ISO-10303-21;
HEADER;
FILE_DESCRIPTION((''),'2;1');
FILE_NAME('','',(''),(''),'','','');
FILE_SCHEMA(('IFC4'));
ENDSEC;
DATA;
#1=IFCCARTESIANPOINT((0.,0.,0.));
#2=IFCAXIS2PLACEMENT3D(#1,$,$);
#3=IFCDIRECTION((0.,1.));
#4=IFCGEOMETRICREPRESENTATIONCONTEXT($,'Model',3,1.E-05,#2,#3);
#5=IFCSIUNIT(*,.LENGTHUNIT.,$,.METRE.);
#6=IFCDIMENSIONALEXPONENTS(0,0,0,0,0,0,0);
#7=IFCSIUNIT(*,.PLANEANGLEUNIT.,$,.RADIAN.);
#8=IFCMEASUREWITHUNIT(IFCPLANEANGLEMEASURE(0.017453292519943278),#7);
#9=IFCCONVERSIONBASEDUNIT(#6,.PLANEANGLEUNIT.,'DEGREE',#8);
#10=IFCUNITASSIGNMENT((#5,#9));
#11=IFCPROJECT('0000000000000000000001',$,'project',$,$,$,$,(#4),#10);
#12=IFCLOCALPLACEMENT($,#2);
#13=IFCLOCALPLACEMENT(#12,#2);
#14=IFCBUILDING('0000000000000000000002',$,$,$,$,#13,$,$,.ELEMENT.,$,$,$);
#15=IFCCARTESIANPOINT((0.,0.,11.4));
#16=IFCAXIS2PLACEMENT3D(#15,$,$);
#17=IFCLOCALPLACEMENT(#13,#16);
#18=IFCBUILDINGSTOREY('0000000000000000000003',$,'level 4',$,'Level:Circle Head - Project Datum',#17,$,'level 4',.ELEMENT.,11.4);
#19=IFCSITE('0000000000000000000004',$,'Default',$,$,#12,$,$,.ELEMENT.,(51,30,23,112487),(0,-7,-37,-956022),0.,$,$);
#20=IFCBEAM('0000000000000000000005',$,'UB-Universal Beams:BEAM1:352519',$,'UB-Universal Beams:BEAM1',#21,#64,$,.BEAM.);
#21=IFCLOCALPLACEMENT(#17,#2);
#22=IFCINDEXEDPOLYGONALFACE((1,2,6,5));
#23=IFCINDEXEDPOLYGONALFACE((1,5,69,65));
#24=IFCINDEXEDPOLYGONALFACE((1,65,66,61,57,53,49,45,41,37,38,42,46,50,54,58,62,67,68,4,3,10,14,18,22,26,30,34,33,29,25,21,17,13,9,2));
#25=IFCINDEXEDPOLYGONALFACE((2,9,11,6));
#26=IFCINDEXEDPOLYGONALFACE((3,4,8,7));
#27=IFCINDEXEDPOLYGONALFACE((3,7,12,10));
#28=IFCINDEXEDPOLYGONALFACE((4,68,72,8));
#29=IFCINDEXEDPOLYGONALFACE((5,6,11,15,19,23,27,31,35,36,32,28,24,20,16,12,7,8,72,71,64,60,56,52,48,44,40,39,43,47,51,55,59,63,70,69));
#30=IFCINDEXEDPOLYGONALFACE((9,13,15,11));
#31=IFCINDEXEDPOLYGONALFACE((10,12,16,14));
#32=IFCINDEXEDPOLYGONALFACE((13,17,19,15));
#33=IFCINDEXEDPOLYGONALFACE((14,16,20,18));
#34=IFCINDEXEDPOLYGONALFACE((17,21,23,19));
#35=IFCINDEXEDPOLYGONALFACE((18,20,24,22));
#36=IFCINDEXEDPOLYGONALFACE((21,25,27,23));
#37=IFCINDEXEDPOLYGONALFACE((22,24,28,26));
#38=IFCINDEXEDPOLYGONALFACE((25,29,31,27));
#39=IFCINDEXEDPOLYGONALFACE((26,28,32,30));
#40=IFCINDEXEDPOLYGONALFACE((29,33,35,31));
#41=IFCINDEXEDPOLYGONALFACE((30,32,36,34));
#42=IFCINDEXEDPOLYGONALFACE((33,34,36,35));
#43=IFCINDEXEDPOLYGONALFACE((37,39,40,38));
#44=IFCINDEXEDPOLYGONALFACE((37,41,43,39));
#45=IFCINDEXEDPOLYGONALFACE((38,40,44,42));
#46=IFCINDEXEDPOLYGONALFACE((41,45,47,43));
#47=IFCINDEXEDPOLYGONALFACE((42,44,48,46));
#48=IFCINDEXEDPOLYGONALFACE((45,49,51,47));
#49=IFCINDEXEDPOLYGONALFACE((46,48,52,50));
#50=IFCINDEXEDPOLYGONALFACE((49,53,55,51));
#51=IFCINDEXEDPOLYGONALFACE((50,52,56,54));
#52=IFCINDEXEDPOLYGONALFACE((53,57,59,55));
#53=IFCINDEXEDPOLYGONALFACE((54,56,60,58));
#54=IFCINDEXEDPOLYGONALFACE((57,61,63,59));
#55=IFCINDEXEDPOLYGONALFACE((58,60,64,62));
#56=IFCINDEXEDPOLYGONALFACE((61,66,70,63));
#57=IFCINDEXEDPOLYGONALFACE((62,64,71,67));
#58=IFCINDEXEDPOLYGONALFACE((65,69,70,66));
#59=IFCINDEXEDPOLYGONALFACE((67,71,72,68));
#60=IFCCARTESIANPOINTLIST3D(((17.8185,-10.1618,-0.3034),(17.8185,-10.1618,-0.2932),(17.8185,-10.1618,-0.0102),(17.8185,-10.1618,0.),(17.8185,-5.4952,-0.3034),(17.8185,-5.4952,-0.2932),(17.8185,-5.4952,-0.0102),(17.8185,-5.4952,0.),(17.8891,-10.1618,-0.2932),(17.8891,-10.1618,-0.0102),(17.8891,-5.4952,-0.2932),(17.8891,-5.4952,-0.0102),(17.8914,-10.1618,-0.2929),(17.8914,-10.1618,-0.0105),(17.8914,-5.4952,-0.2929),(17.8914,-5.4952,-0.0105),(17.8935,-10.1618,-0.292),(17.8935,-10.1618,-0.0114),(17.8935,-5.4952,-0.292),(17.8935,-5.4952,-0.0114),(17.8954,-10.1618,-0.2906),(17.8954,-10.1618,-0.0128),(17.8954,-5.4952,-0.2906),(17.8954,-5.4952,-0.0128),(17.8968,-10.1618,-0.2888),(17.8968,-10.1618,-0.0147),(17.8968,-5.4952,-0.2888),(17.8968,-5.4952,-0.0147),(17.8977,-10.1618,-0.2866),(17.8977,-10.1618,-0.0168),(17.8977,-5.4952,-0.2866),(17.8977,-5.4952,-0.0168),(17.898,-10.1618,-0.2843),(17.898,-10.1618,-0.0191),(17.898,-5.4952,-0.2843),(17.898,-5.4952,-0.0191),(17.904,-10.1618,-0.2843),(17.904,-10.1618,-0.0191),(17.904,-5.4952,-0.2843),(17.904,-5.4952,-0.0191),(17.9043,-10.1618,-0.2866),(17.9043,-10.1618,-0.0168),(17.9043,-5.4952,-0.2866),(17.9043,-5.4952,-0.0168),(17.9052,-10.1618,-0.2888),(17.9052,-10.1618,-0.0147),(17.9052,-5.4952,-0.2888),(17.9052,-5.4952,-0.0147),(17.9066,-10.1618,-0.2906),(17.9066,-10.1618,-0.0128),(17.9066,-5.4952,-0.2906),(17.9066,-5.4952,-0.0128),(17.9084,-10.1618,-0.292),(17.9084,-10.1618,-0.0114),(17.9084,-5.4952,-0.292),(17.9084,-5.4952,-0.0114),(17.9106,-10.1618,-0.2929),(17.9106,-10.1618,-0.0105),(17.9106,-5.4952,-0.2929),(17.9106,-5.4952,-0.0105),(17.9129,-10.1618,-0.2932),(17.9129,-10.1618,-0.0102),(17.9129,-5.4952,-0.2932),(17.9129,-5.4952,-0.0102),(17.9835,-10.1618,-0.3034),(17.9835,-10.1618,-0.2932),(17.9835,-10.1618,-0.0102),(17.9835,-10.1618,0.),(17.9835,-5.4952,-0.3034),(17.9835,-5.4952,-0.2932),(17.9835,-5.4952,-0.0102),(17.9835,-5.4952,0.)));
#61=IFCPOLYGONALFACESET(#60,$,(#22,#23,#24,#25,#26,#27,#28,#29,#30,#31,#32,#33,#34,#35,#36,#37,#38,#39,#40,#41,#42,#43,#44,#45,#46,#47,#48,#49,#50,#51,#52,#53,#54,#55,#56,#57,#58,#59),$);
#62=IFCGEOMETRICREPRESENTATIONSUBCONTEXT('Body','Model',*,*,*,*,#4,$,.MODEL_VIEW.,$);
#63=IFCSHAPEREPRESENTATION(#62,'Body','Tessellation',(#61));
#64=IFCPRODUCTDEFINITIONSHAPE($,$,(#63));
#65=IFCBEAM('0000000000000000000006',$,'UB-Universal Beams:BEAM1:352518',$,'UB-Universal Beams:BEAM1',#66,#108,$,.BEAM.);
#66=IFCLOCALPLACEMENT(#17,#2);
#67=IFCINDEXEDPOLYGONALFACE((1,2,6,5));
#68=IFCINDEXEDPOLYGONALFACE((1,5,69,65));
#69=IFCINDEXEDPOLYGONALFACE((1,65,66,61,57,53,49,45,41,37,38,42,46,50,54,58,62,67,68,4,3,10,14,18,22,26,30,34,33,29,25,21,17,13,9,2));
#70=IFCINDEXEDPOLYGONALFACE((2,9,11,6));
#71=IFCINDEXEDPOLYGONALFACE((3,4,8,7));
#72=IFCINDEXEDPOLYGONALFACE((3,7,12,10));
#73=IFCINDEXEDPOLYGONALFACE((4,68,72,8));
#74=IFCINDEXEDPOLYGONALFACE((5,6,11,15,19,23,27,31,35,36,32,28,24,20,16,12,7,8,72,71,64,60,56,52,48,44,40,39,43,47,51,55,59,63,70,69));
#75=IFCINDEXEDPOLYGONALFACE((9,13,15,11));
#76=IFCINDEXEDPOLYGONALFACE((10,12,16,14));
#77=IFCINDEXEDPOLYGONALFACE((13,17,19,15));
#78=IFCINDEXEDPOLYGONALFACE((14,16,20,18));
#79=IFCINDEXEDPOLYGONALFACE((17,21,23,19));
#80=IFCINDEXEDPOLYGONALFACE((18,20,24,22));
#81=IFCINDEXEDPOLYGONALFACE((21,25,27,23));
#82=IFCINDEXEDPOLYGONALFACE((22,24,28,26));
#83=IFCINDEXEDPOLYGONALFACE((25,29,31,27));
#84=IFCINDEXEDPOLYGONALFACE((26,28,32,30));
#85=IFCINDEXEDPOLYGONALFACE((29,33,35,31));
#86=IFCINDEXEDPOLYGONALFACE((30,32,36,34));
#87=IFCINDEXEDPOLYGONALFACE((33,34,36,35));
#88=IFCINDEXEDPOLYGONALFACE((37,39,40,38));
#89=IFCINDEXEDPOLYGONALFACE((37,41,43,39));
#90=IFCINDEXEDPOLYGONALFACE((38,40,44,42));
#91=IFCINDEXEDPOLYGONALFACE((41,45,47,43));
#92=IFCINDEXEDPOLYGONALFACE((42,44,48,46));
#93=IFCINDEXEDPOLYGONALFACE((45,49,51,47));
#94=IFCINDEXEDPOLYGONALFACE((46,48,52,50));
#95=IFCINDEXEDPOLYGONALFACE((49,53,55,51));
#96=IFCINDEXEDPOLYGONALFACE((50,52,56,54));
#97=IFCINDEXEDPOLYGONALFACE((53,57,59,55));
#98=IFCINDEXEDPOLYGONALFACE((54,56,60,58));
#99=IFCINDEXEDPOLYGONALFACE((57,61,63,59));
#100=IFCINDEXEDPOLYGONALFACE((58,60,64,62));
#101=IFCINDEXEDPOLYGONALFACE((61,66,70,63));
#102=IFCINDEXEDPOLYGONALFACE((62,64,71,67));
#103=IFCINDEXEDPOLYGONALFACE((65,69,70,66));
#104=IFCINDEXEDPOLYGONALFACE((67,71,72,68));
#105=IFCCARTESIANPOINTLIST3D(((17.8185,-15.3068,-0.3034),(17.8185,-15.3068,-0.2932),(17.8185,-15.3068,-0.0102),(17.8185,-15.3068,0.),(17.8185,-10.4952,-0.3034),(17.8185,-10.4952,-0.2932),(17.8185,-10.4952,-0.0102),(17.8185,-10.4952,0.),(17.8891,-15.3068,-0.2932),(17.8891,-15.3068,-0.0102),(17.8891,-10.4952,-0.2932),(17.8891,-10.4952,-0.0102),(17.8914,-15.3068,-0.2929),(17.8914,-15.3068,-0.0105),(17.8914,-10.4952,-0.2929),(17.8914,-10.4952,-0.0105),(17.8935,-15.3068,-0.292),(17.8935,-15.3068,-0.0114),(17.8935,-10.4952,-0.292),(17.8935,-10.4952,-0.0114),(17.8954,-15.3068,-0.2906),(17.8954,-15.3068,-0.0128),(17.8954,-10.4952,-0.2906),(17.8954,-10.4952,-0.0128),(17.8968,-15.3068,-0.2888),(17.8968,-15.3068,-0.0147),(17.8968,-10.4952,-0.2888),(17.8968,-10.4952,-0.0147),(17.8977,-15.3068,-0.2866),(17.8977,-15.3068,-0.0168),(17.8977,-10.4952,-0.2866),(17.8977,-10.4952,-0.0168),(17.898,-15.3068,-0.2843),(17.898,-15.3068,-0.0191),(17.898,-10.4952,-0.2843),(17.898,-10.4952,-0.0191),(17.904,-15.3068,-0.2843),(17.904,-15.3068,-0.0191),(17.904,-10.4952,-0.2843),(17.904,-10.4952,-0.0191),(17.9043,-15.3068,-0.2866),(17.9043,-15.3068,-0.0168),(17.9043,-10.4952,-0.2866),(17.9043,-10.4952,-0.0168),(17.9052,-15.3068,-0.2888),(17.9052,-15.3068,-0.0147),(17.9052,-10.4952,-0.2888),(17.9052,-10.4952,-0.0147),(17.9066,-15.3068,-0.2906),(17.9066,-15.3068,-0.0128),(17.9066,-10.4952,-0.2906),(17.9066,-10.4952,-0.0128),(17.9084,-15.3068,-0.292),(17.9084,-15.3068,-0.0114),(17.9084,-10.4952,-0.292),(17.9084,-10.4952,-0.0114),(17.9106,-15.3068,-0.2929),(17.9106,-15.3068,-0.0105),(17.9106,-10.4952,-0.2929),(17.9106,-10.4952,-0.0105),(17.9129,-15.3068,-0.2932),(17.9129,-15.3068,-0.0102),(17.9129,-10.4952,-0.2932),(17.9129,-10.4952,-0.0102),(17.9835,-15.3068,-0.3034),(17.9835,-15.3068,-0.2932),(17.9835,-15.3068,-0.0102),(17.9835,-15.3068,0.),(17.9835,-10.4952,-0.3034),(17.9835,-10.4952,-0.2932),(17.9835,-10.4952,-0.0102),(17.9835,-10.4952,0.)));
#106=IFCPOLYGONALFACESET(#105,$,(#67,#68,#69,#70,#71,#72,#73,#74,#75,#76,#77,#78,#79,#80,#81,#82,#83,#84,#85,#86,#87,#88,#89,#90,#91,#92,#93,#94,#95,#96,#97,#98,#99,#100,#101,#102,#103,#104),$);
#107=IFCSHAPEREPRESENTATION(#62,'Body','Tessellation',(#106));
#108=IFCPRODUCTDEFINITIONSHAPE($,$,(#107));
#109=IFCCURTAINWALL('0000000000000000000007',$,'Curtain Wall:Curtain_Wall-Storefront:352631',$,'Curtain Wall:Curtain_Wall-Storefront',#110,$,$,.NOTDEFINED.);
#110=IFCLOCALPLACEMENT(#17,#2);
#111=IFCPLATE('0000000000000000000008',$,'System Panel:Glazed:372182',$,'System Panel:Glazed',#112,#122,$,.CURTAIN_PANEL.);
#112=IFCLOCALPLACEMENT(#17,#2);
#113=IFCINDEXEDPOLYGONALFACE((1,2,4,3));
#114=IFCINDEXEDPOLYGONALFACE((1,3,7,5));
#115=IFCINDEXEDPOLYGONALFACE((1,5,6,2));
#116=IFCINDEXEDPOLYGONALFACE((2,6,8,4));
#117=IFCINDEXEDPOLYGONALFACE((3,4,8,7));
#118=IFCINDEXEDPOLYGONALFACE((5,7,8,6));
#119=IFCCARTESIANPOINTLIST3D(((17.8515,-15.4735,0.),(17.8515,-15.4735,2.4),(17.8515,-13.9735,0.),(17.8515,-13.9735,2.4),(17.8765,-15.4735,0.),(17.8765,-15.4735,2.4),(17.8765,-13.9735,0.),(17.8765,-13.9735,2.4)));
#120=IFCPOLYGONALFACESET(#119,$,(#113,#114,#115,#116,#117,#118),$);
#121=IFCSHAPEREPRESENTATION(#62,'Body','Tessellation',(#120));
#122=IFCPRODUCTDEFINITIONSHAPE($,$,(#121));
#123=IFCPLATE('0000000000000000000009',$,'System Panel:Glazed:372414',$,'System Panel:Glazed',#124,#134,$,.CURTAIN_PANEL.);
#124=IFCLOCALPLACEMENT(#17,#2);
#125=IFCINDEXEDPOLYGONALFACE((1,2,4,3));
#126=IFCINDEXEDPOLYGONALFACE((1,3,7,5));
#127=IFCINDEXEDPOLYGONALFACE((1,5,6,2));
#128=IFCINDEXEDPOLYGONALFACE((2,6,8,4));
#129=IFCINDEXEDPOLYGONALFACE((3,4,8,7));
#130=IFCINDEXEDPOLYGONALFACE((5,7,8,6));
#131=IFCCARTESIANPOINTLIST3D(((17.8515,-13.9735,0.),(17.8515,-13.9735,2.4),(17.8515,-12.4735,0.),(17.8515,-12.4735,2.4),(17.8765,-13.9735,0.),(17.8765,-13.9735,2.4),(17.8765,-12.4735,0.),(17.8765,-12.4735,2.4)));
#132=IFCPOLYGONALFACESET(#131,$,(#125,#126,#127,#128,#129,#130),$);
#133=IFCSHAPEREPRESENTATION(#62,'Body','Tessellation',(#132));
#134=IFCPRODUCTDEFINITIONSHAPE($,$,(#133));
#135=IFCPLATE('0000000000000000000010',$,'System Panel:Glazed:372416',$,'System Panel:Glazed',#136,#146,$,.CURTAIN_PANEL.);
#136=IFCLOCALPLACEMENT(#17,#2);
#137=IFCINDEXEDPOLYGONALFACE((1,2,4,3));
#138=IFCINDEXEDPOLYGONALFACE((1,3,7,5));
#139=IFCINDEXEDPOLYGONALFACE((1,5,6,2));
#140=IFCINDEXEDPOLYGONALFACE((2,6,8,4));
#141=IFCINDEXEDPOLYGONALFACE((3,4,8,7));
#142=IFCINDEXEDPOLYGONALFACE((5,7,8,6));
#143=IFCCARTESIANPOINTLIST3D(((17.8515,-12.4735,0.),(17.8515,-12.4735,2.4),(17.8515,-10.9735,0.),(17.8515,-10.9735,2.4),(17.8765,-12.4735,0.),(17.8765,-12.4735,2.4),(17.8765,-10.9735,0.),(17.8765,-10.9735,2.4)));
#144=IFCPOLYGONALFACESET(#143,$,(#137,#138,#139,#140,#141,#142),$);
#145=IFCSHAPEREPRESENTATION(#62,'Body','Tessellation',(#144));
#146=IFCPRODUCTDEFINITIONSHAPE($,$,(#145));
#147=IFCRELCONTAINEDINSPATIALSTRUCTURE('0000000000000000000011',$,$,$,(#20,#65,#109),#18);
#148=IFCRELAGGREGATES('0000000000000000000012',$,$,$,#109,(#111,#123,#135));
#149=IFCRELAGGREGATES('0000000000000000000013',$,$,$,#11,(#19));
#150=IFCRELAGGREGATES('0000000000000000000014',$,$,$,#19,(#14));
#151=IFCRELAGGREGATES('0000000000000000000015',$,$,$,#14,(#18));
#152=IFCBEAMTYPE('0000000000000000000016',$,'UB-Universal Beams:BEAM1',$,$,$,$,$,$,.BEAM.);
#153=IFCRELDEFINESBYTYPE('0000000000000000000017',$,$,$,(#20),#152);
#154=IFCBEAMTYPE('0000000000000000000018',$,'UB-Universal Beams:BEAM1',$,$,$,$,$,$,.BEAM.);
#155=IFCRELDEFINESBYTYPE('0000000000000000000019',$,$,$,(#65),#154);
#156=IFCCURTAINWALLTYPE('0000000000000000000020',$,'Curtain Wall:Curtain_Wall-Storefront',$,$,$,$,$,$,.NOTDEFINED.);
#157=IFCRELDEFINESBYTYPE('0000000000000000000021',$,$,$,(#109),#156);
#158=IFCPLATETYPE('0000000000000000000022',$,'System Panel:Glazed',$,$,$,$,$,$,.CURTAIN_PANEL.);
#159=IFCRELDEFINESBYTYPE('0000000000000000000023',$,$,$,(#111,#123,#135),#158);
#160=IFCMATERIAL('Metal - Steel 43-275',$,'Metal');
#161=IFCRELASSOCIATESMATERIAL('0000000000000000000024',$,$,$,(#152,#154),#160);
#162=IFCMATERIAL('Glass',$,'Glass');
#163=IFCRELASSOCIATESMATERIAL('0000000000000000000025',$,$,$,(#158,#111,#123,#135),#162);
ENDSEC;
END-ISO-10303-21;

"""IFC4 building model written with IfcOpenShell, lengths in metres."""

from ifc_helpers import new_model, entity, si_unit, converted_unit, direction, frame, frame_2d, origin, origin_2d_with_axis, place, context, subcontext, project, spatial, polyline, circle_curve, parameter, trimmed, segment, composite_curve, rectangle, outline, extrude, source, transform, mapped, material, material_profile, profile_set, type_object, type_shapes, element, aggregate, save


model = new_model("IFC4")

# Units and contexts
model_context = context("Model", 3, precision=1e-05, world=origin(), true_north=direction((0.0, 1.0)))
body_context = subcontext(model_context, "Body", "Model", "MODEL_VIEW")
ifc_project = project(units=[si_unit("LENGTHUNIT", "METRE"), converted_unit("PLANEANGLEUNIT", "DEGREE", entity("IfcPlaneAngleMeasure", 0.017453292519943278), si_unit("PLANEANGLEUNIT", "RADIAN"), dimensions=[0, 0, 0, 0, 0, 0, 0])], contexts=[model_context])

# Site, building, storey
site_placement = place(None, origin())
site = spatial("IfcSite", under=ifc_project, at=site_placement, Name="Default", CompositionType="ELEMENT", RefLatitude=(51, 30, 23, 112487), RefLongitude=(0, -7, -37, -956022), RefElevation=0.0)
building_placement = place(site_placement, origin())
building = spatial("IfcBuilding", under=site, at=building_placement, CompositionType="ELEMENT")
storey_placement = place(building_placement, frame((0.0, 0.0, 11.4)))
storey = spatial("IfcBuildingStorey", under=building, at=storey_placement, Name="level 4", ObjectType="Level:Circle Head - Project Datum", LongName="level 4", CompositionType="ELEMENT", Elevation=11.4)

# Beams
ifc_material_1 = material(Name="Metal - Steel 43-275", Category="Metal")
ifc_material_profile = material_profile(ifc_material_1, outline(composite_curve([segment(polyline([(-0.0825, -0.1415), (-0.0825, -0.1517)]), True, "CONTINUOUS"), segment(polyline([(-0.0825, -0.1517), (0.0825, -0.1517)]), True, "CONTINUOUS"), segment(polyline([(0.0825, -0.1517), (0.0825, -0.1415)]), True, "CONTINUOUS"), segment(polyline([(0.0825, -0.1415), (0.0119, -0.1415)]), True, "CONTINUOUS"), segment(trimmed(circle_curve(frame_2d((0.0119, -0.1326), x_axis=(1.0, 0.0)), 0.0089), [parameter(180.0)], [parameter(270.0)], True, "PARAMETER"), False, "CONTINUOUS"), segment(polyline([(0.003, -0.1326), (0.003, 0.1326)]), True, "CONTINUOUS"), segment(trimmed(circle_curve(frame_2d((0.0119, 0.1326), x_axis=(1.0, 0.0)), 0.0089), [parameter(90.0)], [parameter(180.0)], True, "PARAMETER"), False, "CONTINUOUS"), segment(polyline([(0.0119, 0.1415), (0.0825, 0.1415)]), True, "CONTINUOUS"), segment(polyline([(0.0825, 0.1415), (0.0825, 0.1517)]), True, "CONTINUOUS"), segment(polyline([(0.0825, 0.1517), (-0.0825, 0.1517)]), True, "CONTINUOUS"), segment(polyline([(-0.0825, 0.1517), (-0.0825, 0.1415)]), True, "CONTINUOUS"), segment(polyline([(-0.0825, 0.1415), (-0.0119, 0.1415)]), True, "CONTINUOUS"), segment(trimmed(circle_curve(frame_2d((-0.0119, 0.1326), x_axis=(1.0, 0.0)), 0.0089), [parameter(360.0)], [parameter(90.0)], True, "PARAMETER"), False, "CONTINUOUS"), segment(polyline([(-0.003, 0.1326), (-0.003, -0.1326)]), True, "CONTINUOUS"), segment(trimmed(circle_curve(frame_2d((-0.0119, -0.1326), x_axis=(1.0, 0.0)), 0.0089), [parameter(270.0)], [parameter(360.0)], True, "PARAMETER"), False, "CONTINUOUS"), segment(polyline([(-0.0119, -0.1415), (-0.0825, -0.1415)]), True, "CONTINUOUS")], self_intersect=False)), Name="BEAM1")
ifc_profile_set = profile_set([ifc_material_profile], Name="BEAM1")
beam_type_1 = type_object("IfcBeamType", Name="UB-Universal Beams:BEAM1", PredefinedType="BEAM", material=ifc_profile_set)
shared_shape_1 = source(origin(), body_context, "Body", "SweptSolid", [
    extrude(outline(composite_curve([segment(polyline([(-0.0825, -0.1415), (-0.0825, -0.1517)]), True, "CONTINUOUS"), segment(polyline([(-0.0825, -0.1517), (0.0825, -0.1517)]), True, "CONTINUOUS"), segment(polyline([(0.0825, -0.1517), (0.0825, -0.1415)]), True, "CONTINUOUS"), segment(polyline([(0.0825, -0.1415), (0.0119, -0.1415)]), True, "CONTINUOUS"), segment(trimmed(circle_curve(frame_2d((0.0119, -0.1326), x_axis=(0.0, -1.0)), 0.0089), [parameter(270.0)], [parameter(360.0)], True, "PARAMETER"), False, "CONTINUOUS"), segment(polyline([(0.003, -0.1326), (0.003, 0.1326)]), True, "CONTINUOUS"), segment(trimmed(circle_curve(frame_2d((0.0119, 0.1326), x_axis=(-1.0, 0.0)), 0.0089), [parameter(270.0)], [parameter(360.0)], True, "PARAMETER"), False, "CONTINUOUS"), segment(polyline([(0.0119, 0.1415), (0.0825, 0.1415)]), True, "CONTINUOUS"), segment(polyline([(0.0825, 0.1415), (0.0825, 0.1517)]), True, "CONTINUOUS"), segment(polyline([(0.0825, 0.1517), (-0.0825, 0.1517)]), True, "CONTINUOUS"), segment(polyline([(-0.0825, 0.1517), (-0.0825, 0.1415)]), True, "CONTINUOUS"), segment(polyline([(-0.0825, 0.1415), (-0.0119, 0.1415)]), True, "CONTINUOUS"), segment(trimmed(circle_curve(frame_2d((-0.0119, 0.1326), x_axis=(0.0, 1.0)), 0.0089), [parameter(270.0)], [parameter(360.0)], True, "PARAMETER"), False, "CONTINUOUS"), segment(polyline([(-0.003, 0.1326), (-0.003, -0.1326)]), True, "CONTINUOUS"), segment(trimmed(circle_curve(frame_2d((-0.0119, -0.1326), x_axis=(1.0, 0.0)), 0.0089), [parameter(270.0)], [parameter(0.0)], True, "PARAMETER"), False, "CONTINUOUS"), segment(polyline([(-0.0119, -0.1415), (-0.0825, -0.1415)]), True, "CONTINUOUS")], self_intersect=False)), frame((-2.3333, 0.0, 0.0), z_axis=(-1.0, 0.0, 0.0), x_axis=(0.0, -1.0, 0.0)), (0.0, 0.0, -1.0), 4.6666),
])
type_shapes(beam_type_1, [shared_shape_1])
beam_1_placement = place(storey_placement, frame((17.901, -7.8285, -0.1517), z_axis=(0.0, 0.0, 1.0), x_axis=(0.0, -1.0, 0.0)))
element("IfcBeam", 1, at=beam_1_placement, inside=storey, type_object=beam_type_1, Name="UB-Universal Beams:BEAM1:352519", ObjectType="UB-Universal Beams:BEAM1", PredefinedType="BEAM", context=body_context, shape_type="MappedRepresentation", body=[
    mapped(shared_shape_1, transform((0.0, 0.0, 0.0), scale=1.0)),
])
beam_type_2 = type_object("IfcBeamType", Name="UB-Universal Beams:BEAM1", PredefinedType="BEAM", material=ifc_profile_set)
shared_shape_2 = source(origin(), body_context, "Body", "SweptSolid", [
    extrude(outline(composite_curve([segment(polyline([(-0.0825, -0.1415), (-0.0825, -0.1517)]), True, "CONTINUOUS"), segment(polyline([(-0.0825, -0.1517), (0.0825, -0.1517)]), True, "CONTINUOUS"), segment(polyline([(0.0825, -0.1517), (0.0825, -0.1415)]), True, "CONTINUOUS"), segment(polyline([(0.0825, -0.1415), (0.0119, -0.1415)]), True, "CONTINUOUS"), segment(trimmed(circle_curve(frame_2d((0.0119, -0.1326), x_axis=(0.0, -1.0)), 0.0089), [parameter(270.0)], [parameter(360.0)], True, "PARAMETER"), False, "CONTINUOUS"), segment(polyline([(0.003, -0.1326), (0.003, 0.1326)]), True, "CONTINUOUS"), segment(trimmed(circle_curve(frame_2d((0.0119, 0.1326), x_axis=(-1.0, 0.0)), 0.0089), [parameter(270.0)], [parameter(360.0)], True, "PARAMETER"), False, "CONTINUOUS"), segment(polyline([(0.0119, 0.1415), (0.0825, 0.1415)]), True, "CONTINUOUS"), segment(polyline([(0.0825, 0.1415), (0.0825, 0.1517)]), True, "CONTINUOUS"), segment(polyline([(0.0825, 0.1517), (-0.0825, 0.1517)]), True, "CONTINUOUS"), segment(polyline([(-0.0825, 0.1517), (-0.0825, 0.1415)]), True, "CONTINUOUS"), segment(polyline([(-0.0825, 0.1415), (-0.0119, 0.1415)]), True, "CONTINUOUS"), segment(trimmed(circle_curve(frame_2d((-0.0119, 0.1326), x_axis=(0.0, 1.0)), 0.0089), [parameter(270.0)], [parameter(360.0)], True, "PARAMETER"), False, "CONTINUOUS"), segment(polyline([(-0.003, 0.1326), (-0.003, -0.1326)]), True, "CONTINUOUS"), segment(trimmed(circle_curve(frame_2d((-0.0119, -0.1326), x_axis=(1.0, 0.0)), 0.0089), [parameter(270.0)], [parameter(0.0)], True, "PARAMETER"), False, "CONTINUOUS"), segment(polyline([(-0.0119, -0.1415), (-0.0825, -0.1415)]), True, "CONTINUOUS")], self_intersect=False)), frame((-2.4058, 0.0, 0.0), z_axis=(-1.0, 0.0, 0.0), x_axis=(0.0, -1.0, 0.0)), (0.0, 0.0, -1.0), 4.8116),
])
type_shapes(beam_type_2, [shared_shape_2])
beam_2_placement = place(storey_placement, frame((17.901, -12.901, -0.1517), z_axis=(0.0, 0.0, 1.0), x_axis=(0.0, -1.0, 0.0)))
element("IfcBeam", 2, at=beam_2_placement, inside=storey, type_object=beam_type_2, Name="UB-Universal Beams:BEAM1:352518", ObjectType="UB-Universal Beams:BEAM1", PredefinedType="BEAM", context=body_context, shape_type="MappedRepresentation", body=[
    mapped(shared_shape_2, transform((0.0, 0.0, 0.0), scale=1.0)),
])

# Curtain wall, plates
curtain_wall_type = type_object("IfcCurtainWallType", Name="Curtain Wall:Curtain_Wall-Storefront", PredefinedType="NOTDEFINED")
curtain_wall_placement = place(storey_placement, frame((0.0, 0.0, -11.4)))
curtain_wall = element("IfcCurtainWall", 3, at=curtain_wall_placement, inside=storey, type_object=curtain_wall_type, Name="Curtain Wall:Curtain_Wall-Storefront:352631", ObjectType="Curtain Wall:Curtain_Wall-Storefront", PredefinedType="NOTDEFINED")
ifc_material_2 = material(Name="Glass", Category="Glass")
plate_type_1 = type_object("IfcPlateType", Name="System Panel:Glazed", PredefinedType="CURTAIN_PANEL", material=ifc_material_2)
shared_shape_3 = source(origin(), body_context, "Body", "SweptSolid", [
    extrude(rectangle(XDim=0.025, YDim=1.5, at=origin_2d_with_axis()), frame((0.75, 0.0125, 0.0), z_axis=(0.0, 0.0, 1.0), x_axis=(0.0, 1.0, 0.0)), (0.0, 0.0, 1.0), 2.4),
])
type_shapes(plate_type_1, [shared_shape_3])
plate_1_placement = place(curtain_wall_placement, frame((17.8765, -15.4735, 11.4), z_axis=(0.0, 0.0, 1.0), x_axis=(0.0, 1.0, 0.0)))
plate_1 = element("IfcPlate", 4, at=plate_1_placement, type_object=plate_type_1, material=ifc_material_2, Name="System Panel:Glazed:372182", ObjectType="System Panel:Glazed", PredefinedType="CURTAIN_PANEL", context=body_context, shape_type="MappedRepresentation", body=[
    mapped(shared_shape_3, transform((0.0, 0.0, 0.0), scale=1.0)),
])
plate_2_placement = place(curtain_wall_placement, frame((17.8765, -13.9735, 11.4), z_axis=(0.0, 0.0, 1.0), x_axis=(0.0, 1.0, 0.0)))
plate_2 = element("IfcPlate", 5, at=plate_2_placement, type_object=plate_type_1, material=ifc_material_2, Name="System Panel:Glazed:372414", ObjectType="System Panel:Glazed", PredefinedType="CURTAIN_PANEL", context=body_context, shape_type="MappedRepresentation", body=[
    mapped(shared_shape_3, transform((0.0, 0.0, 0.0), scale=1.0)),
])
plate_3_placement = place(curtain_wall_placement, frame((17.8765, -12.4735, 11.4), z_axis=(0.0, 0.0, 1.0), x_axis=(0.0, 1.0, 0.0)))
plate_3 = element("IfcPlate", 6, at=plate_3_placement, type_object=plate_type_1, material=ifc_material_2, Name="System Panel:Glazed:372416", ObjectType="System Panel:Glazed", PredefinedType="CURTAIN_PANEL", context=body_context, shape_type="MappedRepresentation", body=[
    mapped(shared_shape_3, transform((0.0, 0.0, 0.0), scale=1.0)),
])
aggregate(curtain_wall, [plate_1, plate_2, plate_3])

save(model, "model.ifc")
